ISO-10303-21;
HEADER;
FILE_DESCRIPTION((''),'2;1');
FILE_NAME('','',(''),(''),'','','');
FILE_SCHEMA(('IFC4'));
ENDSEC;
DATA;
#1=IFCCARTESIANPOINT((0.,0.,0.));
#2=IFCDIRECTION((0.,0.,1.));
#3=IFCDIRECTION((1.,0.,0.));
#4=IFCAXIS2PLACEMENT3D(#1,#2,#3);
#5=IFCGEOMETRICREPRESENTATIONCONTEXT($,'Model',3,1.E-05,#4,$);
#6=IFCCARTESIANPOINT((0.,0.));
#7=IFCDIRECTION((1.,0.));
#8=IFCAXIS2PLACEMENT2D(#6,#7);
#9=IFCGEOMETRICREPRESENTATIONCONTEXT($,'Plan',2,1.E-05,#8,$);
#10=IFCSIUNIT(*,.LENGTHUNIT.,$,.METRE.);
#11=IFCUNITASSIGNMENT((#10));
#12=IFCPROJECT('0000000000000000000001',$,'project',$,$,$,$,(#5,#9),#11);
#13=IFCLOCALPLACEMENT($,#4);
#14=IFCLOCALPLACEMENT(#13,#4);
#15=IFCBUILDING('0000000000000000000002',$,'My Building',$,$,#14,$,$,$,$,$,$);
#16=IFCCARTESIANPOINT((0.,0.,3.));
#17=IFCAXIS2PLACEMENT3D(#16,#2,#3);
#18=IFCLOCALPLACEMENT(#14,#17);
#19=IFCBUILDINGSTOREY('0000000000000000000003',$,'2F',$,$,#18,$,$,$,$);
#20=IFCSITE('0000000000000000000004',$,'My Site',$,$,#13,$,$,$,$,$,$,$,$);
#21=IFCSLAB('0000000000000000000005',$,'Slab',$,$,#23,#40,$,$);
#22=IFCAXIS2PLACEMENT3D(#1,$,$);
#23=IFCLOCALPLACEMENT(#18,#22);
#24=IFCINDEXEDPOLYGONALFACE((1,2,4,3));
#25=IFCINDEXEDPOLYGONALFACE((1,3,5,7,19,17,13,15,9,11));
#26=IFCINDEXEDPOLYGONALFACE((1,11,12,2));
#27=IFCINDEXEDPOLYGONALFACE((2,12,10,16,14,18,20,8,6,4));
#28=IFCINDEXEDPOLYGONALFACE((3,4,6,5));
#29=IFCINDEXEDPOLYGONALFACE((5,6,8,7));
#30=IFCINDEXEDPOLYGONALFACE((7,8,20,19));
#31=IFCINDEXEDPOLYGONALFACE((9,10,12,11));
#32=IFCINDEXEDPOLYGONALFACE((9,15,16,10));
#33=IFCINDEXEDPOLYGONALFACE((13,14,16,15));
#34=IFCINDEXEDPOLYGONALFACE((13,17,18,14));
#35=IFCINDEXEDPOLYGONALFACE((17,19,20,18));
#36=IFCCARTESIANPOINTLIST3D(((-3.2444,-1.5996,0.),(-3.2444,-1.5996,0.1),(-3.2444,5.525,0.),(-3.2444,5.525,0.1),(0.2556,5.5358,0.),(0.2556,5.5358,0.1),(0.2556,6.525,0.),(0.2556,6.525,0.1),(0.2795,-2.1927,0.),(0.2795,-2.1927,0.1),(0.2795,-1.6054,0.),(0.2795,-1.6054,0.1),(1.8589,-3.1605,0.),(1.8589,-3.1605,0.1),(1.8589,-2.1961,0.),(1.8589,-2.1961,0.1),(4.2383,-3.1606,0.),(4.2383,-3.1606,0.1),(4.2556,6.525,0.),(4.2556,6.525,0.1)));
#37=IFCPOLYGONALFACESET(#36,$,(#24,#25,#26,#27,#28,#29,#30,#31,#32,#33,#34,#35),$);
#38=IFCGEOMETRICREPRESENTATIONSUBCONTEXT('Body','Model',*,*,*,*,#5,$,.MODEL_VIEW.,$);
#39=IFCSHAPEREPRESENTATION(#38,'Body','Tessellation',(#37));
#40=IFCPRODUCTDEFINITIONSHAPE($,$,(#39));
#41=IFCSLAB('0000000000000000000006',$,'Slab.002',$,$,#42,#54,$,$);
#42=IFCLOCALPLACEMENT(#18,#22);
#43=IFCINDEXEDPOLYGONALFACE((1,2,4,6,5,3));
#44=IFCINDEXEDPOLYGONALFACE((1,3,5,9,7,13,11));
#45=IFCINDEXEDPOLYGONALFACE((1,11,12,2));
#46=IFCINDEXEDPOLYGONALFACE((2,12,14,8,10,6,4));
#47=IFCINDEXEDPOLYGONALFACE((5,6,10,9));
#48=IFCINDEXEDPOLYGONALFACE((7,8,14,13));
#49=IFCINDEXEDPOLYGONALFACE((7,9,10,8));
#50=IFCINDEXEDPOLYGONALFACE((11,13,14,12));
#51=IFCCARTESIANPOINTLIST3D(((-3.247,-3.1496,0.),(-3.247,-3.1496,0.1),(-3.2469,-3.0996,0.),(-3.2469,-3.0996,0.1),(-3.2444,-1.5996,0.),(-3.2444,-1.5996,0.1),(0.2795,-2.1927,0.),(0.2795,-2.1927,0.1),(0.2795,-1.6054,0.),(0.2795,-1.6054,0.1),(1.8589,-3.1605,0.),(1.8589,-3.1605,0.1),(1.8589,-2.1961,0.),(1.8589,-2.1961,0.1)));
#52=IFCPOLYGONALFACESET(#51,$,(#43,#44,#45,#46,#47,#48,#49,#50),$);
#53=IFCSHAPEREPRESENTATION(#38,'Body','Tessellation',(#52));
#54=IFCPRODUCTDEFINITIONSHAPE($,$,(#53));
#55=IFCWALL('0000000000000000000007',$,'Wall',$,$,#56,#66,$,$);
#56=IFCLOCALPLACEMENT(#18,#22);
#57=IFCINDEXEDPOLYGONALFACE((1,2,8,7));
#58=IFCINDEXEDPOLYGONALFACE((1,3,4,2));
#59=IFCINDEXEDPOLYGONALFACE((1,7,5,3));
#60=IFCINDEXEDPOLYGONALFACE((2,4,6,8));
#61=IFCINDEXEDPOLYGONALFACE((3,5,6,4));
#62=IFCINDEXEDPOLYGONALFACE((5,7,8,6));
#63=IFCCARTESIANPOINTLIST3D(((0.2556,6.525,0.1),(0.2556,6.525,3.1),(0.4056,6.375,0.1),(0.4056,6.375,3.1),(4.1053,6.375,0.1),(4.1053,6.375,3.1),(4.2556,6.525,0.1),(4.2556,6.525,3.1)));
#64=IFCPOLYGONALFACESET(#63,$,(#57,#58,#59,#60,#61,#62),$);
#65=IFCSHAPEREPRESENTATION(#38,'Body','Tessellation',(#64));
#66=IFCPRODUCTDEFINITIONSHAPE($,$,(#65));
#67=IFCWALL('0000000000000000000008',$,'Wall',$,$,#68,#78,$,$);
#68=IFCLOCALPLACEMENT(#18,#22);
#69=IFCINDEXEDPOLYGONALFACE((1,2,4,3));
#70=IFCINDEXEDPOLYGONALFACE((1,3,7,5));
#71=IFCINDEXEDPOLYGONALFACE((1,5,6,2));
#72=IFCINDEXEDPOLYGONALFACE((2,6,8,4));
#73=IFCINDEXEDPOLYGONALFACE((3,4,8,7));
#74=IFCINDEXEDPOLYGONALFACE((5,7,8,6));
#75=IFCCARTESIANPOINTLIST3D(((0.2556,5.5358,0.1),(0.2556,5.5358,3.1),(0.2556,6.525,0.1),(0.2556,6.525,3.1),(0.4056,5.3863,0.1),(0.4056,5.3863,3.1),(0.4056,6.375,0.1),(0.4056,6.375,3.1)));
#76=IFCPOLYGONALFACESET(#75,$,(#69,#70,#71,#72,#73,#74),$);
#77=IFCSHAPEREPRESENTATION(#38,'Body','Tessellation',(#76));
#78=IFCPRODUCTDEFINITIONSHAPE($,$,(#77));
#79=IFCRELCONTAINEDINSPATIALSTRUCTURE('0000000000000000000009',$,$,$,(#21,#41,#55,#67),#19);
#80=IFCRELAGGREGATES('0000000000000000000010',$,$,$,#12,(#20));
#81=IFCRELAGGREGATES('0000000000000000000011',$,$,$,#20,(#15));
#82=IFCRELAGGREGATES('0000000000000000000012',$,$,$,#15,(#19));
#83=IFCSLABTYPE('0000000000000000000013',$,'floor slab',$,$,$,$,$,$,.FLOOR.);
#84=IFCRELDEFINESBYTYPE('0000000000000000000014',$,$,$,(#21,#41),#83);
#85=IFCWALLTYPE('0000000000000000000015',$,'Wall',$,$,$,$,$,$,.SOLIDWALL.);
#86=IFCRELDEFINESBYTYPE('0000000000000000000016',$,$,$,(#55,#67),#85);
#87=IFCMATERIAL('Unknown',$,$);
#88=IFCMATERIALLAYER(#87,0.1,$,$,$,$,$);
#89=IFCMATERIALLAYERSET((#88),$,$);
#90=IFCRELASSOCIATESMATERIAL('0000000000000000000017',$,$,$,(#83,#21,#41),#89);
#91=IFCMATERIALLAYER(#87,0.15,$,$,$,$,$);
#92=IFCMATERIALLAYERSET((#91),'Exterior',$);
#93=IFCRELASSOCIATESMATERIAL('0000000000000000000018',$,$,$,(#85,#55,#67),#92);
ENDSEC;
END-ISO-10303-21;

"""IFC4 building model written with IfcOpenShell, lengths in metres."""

from ifc_helpers import new_model, si_unit, frame, origin_with_axes, origin_2d_with_axis, place, context, subcontext, project, spatial, line, indexed_curve, outline, extrude, material, layer, layer_set, layer_usage, type_object, element, save


model = new_model("IFC4")

# Units and contexts
model_context = context("Model", 3, precision=1e-05, world=origin_with_axes())
plan_context = context("Plan", 2, precision=1e-05, world=origin_2d_with_axis())
body_context_1 = subcontext(model_context, "Body", "Model", "MODEL_VIEW")
ifc_project = project(units=[si_unit("LENGTHUNIT", "METRE")], contexts=[model_context, plan_context])

# Site, building, storey
site_placement = place(None, origin_with_axes())
site = spatial("IfcSite", under=ifc_project, at=site_placement, Name="My Site")
building_placement = place(site_placement, origin_with_axes())
building = spatial("IfcBuilding", under=site, at=building_placement, Name="My Building")
storey_placement = place(building_placement, frame((0.0, 0.0, 3.0), z_axis=(0.0, 0.0, 1.0), x_axis=(1.0, 0.0, 0.0)))
storey = spatial("IfcBuildingStorey", under=building, at=storey_placement, Name="2F")

# Slabs
ifc_material = material(Name="Unknown")
ifc_layer_1 = layer(ifc_material, 0.1)
ifc_layer_set_1 = layer_set([ifc_layer_1])
ifc_layer_usage_1 = layer_usage(ifc_layer_set_1, "AXIS3", "POSITIVE", -0.1)
slab_type = type_object("IfcSlabType", Name="floor slab", PredefinedType="FLOOR", material=ifc_layer_set_1)
slab_1_placement = place(storey_placement, frame((4.2383, -3.1606, 0.1), z_axis=(0.0, 0.0, 1.0), x_axis=(1.0, 0.0, 0.0)))
element("IfcSlab", 1, at=slab_1_placement, inside=storey, type_object=slab_type, material=ifc_layer_usage_1, Name="Slab", context=body_context_1, shape_type="SweptSolid", body=[
    extrude(outline(indexed_curve([(0.0, 0.0), (0.0172, 9.6856), (-3.9827, 9.6856), (-3.9827, 8.6964), (-7.4827, 8.6856), (-7.4827, 1.5611), (-3.9588, 1.5553), (-3.9588, 0.9679), (-2.3795, 0.9645), (-2.3795, 0.0001), (0.0, 0.0)])), frame((0.0, 0.0, -0.1), z_axis=(0.0, 0.0, 1.0), x_axis=(1.0, 0.0, 0.0)), (0.0, 0.0, 1.0), 0.1),
])
ifc_layer_usage_2 = layer_usage(ifc_layer_set_1, "AXIS3", "POSITIVE", -0.1)
slab_2_placement = place(storey_placement, frame((1.8589, -3.1605, 0.1), z_axis=(0.0, 0.0, 1.0), x_axis=(1.0, 0.0, 0.0)))
element("IfcSlab", 2, at=slab_2_placement, inside=storey, type_object=slab_type, material=ifc_layer_usage_2, Name="Slab.002", context=body_context_1, shape_type="SweptSolid", body=[
    extrude(outline(indexed_curve([(0.0, 0.0), (0.0, 0.9644), (-1.5793, 0.9678), (-1.5793, 1.5551), (-5.1033, 1.5609), (-5.1057, 0.0609), (-5.1058, 0.0109), (0.0, 0.0)])), frame((0.0, 0.0, -0.1), z_axis=(0.0, 0.0, 1.0), x_axis=(1.0, 0.0, 0.0)), (0.0, 0.0, 1.0), 0.1),
])

# Walls
ifc_layer_2 = layer(ifc_material, 0.15)
ifc_layer_set_2 = layer_set([ifc_layer_2], Name="Exterior")
ifc_layer_usage_3 = layer_usage(ifc_layer_set_2, "AXIS2", "POSITIVE", 0.0)
wall_type_1 = type_object("IfcWallType", Name="Wall", PredefinedType="SOLIDWALL", material=ifc_layer_set_2)
wall_1_placement = place(storey_placement, frame((4.2556, 6.525, 0.1), z_axis=(0.0, 0.0, 1.0), x_axis=(-1.0, 0.0, 0.0)))
element("IfcWall", 3, at=wall_1_placement, inside=storey, type_object=wall_type_1, material=ifc_layer_usage_3, Name="Wall", context=body_context_1, shape_type="SweptSolid", body=[
    extrude(outline(indexed_curve([(0.0, 0.0), (0.1503, 0.15), (3.85, 0.15), (4.0, 0.0)], segments=[line(1, 2, 3, 4, 1)])), origin_with_axes(), (0.0, 0.0, 1.0), 3.0),
])
ifc_layer_usage_4 = layer_usage(ifc_layer_set_2, "AXIS2", "POSITIVE", 0.0)
wall_2_placement = place(storey_placement, frame((0.2556, 6.525, 0.1), z_axis=(0.0, 0.0, 1.0), x_axis=(0.0, -1.0, 0.0)))
element("IfcWall", 4, at=wall_2_placement, inside=storey, type_object=wall_type_1, material=ifc_layer_usage_4, Name="Wall", context=body_context_1, shape_type="SweptSolid", body=[
    extrude(outline(indexed_curve([(0.0, 0.0), (0.15, 0.15), (1.1387, 0.15), (0.9892, 0.0)], segments=[line(1, 2, 3, 4, 1)])), origin_with_axes(), (0.0, 0.0, 1.0), 3.0),
])

save(model, "model.ifc")
